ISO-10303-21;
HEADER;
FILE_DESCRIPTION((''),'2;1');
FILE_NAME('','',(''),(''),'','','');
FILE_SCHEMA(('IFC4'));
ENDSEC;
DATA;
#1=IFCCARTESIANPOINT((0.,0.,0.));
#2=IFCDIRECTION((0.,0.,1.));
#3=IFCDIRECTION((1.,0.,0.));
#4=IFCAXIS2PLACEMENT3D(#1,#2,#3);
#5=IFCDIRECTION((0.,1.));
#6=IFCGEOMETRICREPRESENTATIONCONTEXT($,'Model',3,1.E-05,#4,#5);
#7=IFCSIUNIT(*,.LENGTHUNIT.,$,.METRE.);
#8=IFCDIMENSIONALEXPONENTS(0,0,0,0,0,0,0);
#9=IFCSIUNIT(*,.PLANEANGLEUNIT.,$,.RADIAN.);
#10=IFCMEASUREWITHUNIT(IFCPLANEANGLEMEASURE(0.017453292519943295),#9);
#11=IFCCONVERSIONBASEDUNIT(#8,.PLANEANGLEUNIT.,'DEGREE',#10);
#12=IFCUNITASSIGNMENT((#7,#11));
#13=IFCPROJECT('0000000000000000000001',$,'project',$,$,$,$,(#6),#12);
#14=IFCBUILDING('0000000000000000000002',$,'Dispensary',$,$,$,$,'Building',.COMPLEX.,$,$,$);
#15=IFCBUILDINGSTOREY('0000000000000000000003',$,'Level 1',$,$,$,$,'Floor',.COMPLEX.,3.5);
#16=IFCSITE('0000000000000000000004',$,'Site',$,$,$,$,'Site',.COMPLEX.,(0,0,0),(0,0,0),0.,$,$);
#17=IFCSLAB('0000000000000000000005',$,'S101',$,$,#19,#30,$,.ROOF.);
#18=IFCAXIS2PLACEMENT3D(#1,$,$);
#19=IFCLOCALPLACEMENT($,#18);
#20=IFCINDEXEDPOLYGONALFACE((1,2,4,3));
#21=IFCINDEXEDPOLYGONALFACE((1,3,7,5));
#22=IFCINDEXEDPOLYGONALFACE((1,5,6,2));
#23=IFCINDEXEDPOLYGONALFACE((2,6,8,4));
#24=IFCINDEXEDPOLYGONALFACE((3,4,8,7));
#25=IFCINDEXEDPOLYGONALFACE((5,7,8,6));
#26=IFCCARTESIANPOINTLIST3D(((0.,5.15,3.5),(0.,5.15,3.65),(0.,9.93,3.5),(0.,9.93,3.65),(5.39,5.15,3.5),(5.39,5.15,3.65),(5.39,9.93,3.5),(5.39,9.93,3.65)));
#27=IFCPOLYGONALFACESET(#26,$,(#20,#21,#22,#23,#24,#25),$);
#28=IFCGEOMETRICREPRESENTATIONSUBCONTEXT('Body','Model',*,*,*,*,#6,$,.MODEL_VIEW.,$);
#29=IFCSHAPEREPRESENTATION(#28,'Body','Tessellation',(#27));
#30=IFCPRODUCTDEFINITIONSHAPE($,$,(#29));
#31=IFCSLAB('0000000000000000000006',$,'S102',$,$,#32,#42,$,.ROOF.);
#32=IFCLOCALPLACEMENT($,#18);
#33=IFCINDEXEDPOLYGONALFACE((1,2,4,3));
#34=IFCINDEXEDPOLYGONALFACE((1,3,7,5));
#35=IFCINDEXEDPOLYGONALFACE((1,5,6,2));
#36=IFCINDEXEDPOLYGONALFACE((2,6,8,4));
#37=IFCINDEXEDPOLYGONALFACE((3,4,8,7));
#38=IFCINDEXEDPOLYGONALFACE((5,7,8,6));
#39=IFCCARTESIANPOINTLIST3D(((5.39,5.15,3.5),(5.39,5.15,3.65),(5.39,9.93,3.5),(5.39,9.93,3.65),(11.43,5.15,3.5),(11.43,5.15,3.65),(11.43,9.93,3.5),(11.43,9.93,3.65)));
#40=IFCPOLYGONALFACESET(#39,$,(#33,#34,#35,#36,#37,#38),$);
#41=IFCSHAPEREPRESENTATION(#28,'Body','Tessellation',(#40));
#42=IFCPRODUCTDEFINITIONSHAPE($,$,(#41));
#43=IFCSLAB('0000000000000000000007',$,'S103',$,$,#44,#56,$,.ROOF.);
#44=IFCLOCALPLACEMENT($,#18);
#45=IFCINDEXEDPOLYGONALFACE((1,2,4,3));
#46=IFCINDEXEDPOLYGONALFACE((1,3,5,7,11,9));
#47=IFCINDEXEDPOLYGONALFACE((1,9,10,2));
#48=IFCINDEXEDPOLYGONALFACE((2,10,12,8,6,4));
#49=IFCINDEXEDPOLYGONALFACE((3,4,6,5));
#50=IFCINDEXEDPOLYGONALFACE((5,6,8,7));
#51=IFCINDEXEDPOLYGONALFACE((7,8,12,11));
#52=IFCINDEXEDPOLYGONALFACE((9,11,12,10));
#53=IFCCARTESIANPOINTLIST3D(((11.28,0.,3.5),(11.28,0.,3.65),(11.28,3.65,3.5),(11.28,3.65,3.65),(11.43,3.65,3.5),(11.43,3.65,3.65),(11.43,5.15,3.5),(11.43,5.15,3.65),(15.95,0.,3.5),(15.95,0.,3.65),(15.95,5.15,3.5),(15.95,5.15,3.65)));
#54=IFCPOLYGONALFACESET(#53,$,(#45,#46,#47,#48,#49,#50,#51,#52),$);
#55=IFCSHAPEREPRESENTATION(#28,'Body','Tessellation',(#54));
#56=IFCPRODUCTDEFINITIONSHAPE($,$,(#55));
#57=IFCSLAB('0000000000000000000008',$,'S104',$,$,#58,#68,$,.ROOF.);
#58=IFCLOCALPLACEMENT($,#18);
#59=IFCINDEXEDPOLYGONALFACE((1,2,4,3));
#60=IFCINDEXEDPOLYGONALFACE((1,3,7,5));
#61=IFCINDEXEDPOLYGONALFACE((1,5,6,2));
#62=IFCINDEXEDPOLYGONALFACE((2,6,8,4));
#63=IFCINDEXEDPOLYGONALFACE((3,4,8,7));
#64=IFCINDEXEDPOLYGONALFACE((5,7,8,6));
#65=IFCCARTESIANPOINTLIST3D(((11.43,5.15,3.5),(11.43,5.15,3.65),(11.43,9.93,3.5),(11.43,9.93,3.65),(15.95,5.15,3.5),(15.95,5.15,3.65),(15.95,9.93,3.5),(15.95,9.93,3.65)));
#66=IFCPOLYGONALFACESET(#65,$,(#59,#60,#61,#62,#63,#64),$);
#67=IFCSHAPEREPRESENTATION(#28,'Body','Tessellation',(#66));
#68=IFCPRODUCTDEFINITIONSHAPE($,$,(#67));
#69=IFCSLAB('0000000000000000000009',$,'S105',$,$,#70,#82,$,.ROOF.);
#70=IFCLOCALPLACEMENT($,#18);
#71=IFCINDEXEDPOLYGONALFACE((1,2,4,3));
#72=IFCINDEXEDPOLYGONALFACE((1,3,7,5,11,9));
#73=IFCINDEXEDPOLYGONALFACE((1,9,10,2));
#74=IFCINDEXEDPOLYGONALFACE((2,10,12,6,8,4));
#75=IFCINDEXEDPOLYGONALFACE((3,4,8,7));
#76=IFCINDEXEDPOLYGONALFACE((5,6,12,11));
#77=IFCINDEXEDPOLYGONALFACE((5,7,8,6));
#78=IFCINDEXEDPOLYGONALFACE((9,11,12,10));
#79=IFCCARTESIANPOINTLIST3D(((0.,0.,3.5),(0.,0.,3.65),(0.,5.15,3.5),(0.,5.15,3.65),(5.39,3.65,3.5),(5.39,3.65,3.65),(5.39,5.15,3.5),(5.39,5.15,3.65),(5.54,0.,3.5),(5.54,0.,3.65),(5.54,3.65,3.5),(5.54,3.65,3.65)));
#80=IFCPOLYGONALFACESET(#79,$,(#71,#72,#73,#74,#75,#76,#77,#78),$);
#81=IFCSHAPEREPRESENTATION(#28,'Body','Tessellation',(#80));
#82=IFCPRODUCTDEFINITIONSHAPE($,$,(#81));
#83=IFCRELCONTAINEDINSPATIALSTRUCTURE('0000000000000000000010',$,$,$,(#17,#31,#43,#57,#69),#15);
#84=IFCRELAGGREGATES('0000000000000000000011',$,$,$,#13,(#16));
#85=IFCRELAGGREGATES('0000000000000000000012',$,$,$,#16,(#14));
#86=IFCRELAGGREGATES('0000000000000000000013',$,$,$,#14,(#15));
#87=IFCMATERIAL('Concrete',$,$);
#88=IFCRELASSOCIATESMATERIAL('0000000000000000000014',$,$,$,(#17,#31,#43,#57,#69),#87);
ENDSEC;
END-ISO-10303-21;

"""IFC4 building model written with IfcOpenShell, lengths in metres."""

from ifc_helpers import new_model, entity, si_unit, converted_unit, direction, frame, frame_2d, origin_with_axes, place, context, subcontext, project, spatial, rectangle, extrude, material, element, save


model = new_model("IFC4")

# Units and contexts
model_context = context("Model", 3, precision=1e-05, world=origin_with_axes(), true_north=direction((0.0, 1.0)))
body_context = subcontext(model_context, "Body", "Model", "MODEL_VIEW")
ifc_project = project(units=[si_unit("LENGTHUNIT", "METRE"), converted_unit("PLANEANGLEUNIT", "DEGREE", entity("IfcPlaneAngleMeasure", 0.017453292519943295), si_unit("PLANEANGLEUNIT", "RADIAN"), dimensions=[0, 0, 0, 0, 0, 0, 0])], contexts=[model_context])

# Site, building, storey
site = spatial("IfcSite", under=ifc_project, Name="Site", LongName="Site", CompositionType="COMPLEX", RefLatitude=(0, 0, 0), RefLongitude=(0, 0, 0), RefElevation=0.0)
building = spatial("IfcBuilding", under=site, Name="Dispensary", LongName="Building", CompositionType="COMPLEX")
storey = spatial("IfcBuildingStorey", under=building, Name="Level 1", LongName="Floor", CompositionType="COMPLEX", Elevation=3.5)

# Slabs
ifc_material_1 = material(Name="Concrete")
placement = place(None, origin_with_axes())
element("IfcSlab", 1, at=placement, inside=storey, material=ifc_material_1, Name="S101", PredefinedType="ROOF", context=body_context, shape_type="SweptSolid", body=[
    extrude(rectangle(XDim=5.39, YDim=4.78, at=frame_2d((0.0, 0.0), x_axis=(-1.0, 0.0))), frame((2.695, 7.54, 3.5), z_axis=(0.0, 0.0, 1.0), x_axis=(1.0, 0.0, 0.0)), (0.0, 0.0, 1.0), 0.15),
])
element("IfcSlab", 2, at=placement, inside=storey, material=ifc_material_1, Name="S102", PredefinedType="ROOF", context=body_context, shape_type="SweptSolid", body=[
    extrude(rectangle(XDim=6.04, YDim=4.78, at=frame_2d((0.0, 0.0), x_axis=(-1.0, 0.0))), frame((8.41, 7.54, 3.5), z_axis=(0.0, 0.0, 1.0), x_axis=(1.0, 0.0, 0.0)), (0.0, 0.0, 1.0), 0.15),
])

# Slab, opening
slab_1 = element("IfcSlab", 3, at=placement, inside=storey, material=ifc_material_1, Name="S103", PredefinedType="ROOF", context=body_context, shape_type="SweptSolid", body=[
    extrude(rectangle(XDim=4.67, YDim=5.15, at=frame_2d((0.0, 0.0), x_axis=(-1.0, 0.0))), frame((13.615, 2.575, 3.5), z_axis=(0.0, 0.0, 1.0), x_axis=(1.0, 0.0, 0.0)), (0.0, 0.0, 1.0), 0.15),
])
element("IfcOpeningElement", 4, at=placement, cuts=slab_1, context=body_context, shape_type="SweptSolid", body=[
    extrude(rectangle(XDim=6.04, YDim=1.5, at=frame_2d((0.0, 0.0), x_axis=(-1.0, 0.0))), frame((8.41, 4.4, 3.5), z_axis=(0.0, 0.0, 1.0), x_axis=(1.0, 0.0, 0.0)), (0.0, 0.0, 1.0), 0.15),
])

# Slab
element("IfcSlab", 5, at=placement, inside=storey, material=ifc_material_1, Name="S104", PredefinedType="ROOF", context=body_context, shape_type="SweptSolid", body=[
    extrude(rectangle(XDim=4.52, YDim=4.78, at=frame_2d((0.0, 0.0), x_axis=(-1.0, 0.0))), frame((13.69, 7.54, 3.5), z_axis=(0.0, 0.0, 1.0), x_axis=(1.0, 0.0, 0.0)), (0.0, 0.0, 1.0), 0.15),
])

# Slab, opening
slab_2 = element("IfcSlab", 6, at=placement, inside=storey, material=ifc_material_1, Name="S105", PredefinedType="ROOF", context=body_context, shape_type="SweptSolid", body=[
    extrude(rectangle(XDim=5.54, YDim=5.15, at=frame_2d((0.0, 0.0), x_axis=(-1.0, 0.0))), frame((2.77, 2.575, 3.5), z_axis=(0.0, 0.0, 1.0), x_axis=(1.0, 0.0, 0.0)), (0.0, 0.0, 1.0), 0.15),
])
element("IfcOpeningElement", 7, at=placement, cuts=slab_2, context=body_context, shape_type="SweptSolid", body=[
    extrude(rectangle(XDim=6.04, YDim=1.5, at=frame_2d((0.0, 0.0), x_axis=(-1.0, 0.0))), frame((8.41, 4.4, 3.5), z_axis=(0.0, 0.0, 1.0), x_axis=(1.0, 0.0, 0.0)), (0.0, 0.0, 1.0), 0.15),
])

save(model, "model.ifc")
